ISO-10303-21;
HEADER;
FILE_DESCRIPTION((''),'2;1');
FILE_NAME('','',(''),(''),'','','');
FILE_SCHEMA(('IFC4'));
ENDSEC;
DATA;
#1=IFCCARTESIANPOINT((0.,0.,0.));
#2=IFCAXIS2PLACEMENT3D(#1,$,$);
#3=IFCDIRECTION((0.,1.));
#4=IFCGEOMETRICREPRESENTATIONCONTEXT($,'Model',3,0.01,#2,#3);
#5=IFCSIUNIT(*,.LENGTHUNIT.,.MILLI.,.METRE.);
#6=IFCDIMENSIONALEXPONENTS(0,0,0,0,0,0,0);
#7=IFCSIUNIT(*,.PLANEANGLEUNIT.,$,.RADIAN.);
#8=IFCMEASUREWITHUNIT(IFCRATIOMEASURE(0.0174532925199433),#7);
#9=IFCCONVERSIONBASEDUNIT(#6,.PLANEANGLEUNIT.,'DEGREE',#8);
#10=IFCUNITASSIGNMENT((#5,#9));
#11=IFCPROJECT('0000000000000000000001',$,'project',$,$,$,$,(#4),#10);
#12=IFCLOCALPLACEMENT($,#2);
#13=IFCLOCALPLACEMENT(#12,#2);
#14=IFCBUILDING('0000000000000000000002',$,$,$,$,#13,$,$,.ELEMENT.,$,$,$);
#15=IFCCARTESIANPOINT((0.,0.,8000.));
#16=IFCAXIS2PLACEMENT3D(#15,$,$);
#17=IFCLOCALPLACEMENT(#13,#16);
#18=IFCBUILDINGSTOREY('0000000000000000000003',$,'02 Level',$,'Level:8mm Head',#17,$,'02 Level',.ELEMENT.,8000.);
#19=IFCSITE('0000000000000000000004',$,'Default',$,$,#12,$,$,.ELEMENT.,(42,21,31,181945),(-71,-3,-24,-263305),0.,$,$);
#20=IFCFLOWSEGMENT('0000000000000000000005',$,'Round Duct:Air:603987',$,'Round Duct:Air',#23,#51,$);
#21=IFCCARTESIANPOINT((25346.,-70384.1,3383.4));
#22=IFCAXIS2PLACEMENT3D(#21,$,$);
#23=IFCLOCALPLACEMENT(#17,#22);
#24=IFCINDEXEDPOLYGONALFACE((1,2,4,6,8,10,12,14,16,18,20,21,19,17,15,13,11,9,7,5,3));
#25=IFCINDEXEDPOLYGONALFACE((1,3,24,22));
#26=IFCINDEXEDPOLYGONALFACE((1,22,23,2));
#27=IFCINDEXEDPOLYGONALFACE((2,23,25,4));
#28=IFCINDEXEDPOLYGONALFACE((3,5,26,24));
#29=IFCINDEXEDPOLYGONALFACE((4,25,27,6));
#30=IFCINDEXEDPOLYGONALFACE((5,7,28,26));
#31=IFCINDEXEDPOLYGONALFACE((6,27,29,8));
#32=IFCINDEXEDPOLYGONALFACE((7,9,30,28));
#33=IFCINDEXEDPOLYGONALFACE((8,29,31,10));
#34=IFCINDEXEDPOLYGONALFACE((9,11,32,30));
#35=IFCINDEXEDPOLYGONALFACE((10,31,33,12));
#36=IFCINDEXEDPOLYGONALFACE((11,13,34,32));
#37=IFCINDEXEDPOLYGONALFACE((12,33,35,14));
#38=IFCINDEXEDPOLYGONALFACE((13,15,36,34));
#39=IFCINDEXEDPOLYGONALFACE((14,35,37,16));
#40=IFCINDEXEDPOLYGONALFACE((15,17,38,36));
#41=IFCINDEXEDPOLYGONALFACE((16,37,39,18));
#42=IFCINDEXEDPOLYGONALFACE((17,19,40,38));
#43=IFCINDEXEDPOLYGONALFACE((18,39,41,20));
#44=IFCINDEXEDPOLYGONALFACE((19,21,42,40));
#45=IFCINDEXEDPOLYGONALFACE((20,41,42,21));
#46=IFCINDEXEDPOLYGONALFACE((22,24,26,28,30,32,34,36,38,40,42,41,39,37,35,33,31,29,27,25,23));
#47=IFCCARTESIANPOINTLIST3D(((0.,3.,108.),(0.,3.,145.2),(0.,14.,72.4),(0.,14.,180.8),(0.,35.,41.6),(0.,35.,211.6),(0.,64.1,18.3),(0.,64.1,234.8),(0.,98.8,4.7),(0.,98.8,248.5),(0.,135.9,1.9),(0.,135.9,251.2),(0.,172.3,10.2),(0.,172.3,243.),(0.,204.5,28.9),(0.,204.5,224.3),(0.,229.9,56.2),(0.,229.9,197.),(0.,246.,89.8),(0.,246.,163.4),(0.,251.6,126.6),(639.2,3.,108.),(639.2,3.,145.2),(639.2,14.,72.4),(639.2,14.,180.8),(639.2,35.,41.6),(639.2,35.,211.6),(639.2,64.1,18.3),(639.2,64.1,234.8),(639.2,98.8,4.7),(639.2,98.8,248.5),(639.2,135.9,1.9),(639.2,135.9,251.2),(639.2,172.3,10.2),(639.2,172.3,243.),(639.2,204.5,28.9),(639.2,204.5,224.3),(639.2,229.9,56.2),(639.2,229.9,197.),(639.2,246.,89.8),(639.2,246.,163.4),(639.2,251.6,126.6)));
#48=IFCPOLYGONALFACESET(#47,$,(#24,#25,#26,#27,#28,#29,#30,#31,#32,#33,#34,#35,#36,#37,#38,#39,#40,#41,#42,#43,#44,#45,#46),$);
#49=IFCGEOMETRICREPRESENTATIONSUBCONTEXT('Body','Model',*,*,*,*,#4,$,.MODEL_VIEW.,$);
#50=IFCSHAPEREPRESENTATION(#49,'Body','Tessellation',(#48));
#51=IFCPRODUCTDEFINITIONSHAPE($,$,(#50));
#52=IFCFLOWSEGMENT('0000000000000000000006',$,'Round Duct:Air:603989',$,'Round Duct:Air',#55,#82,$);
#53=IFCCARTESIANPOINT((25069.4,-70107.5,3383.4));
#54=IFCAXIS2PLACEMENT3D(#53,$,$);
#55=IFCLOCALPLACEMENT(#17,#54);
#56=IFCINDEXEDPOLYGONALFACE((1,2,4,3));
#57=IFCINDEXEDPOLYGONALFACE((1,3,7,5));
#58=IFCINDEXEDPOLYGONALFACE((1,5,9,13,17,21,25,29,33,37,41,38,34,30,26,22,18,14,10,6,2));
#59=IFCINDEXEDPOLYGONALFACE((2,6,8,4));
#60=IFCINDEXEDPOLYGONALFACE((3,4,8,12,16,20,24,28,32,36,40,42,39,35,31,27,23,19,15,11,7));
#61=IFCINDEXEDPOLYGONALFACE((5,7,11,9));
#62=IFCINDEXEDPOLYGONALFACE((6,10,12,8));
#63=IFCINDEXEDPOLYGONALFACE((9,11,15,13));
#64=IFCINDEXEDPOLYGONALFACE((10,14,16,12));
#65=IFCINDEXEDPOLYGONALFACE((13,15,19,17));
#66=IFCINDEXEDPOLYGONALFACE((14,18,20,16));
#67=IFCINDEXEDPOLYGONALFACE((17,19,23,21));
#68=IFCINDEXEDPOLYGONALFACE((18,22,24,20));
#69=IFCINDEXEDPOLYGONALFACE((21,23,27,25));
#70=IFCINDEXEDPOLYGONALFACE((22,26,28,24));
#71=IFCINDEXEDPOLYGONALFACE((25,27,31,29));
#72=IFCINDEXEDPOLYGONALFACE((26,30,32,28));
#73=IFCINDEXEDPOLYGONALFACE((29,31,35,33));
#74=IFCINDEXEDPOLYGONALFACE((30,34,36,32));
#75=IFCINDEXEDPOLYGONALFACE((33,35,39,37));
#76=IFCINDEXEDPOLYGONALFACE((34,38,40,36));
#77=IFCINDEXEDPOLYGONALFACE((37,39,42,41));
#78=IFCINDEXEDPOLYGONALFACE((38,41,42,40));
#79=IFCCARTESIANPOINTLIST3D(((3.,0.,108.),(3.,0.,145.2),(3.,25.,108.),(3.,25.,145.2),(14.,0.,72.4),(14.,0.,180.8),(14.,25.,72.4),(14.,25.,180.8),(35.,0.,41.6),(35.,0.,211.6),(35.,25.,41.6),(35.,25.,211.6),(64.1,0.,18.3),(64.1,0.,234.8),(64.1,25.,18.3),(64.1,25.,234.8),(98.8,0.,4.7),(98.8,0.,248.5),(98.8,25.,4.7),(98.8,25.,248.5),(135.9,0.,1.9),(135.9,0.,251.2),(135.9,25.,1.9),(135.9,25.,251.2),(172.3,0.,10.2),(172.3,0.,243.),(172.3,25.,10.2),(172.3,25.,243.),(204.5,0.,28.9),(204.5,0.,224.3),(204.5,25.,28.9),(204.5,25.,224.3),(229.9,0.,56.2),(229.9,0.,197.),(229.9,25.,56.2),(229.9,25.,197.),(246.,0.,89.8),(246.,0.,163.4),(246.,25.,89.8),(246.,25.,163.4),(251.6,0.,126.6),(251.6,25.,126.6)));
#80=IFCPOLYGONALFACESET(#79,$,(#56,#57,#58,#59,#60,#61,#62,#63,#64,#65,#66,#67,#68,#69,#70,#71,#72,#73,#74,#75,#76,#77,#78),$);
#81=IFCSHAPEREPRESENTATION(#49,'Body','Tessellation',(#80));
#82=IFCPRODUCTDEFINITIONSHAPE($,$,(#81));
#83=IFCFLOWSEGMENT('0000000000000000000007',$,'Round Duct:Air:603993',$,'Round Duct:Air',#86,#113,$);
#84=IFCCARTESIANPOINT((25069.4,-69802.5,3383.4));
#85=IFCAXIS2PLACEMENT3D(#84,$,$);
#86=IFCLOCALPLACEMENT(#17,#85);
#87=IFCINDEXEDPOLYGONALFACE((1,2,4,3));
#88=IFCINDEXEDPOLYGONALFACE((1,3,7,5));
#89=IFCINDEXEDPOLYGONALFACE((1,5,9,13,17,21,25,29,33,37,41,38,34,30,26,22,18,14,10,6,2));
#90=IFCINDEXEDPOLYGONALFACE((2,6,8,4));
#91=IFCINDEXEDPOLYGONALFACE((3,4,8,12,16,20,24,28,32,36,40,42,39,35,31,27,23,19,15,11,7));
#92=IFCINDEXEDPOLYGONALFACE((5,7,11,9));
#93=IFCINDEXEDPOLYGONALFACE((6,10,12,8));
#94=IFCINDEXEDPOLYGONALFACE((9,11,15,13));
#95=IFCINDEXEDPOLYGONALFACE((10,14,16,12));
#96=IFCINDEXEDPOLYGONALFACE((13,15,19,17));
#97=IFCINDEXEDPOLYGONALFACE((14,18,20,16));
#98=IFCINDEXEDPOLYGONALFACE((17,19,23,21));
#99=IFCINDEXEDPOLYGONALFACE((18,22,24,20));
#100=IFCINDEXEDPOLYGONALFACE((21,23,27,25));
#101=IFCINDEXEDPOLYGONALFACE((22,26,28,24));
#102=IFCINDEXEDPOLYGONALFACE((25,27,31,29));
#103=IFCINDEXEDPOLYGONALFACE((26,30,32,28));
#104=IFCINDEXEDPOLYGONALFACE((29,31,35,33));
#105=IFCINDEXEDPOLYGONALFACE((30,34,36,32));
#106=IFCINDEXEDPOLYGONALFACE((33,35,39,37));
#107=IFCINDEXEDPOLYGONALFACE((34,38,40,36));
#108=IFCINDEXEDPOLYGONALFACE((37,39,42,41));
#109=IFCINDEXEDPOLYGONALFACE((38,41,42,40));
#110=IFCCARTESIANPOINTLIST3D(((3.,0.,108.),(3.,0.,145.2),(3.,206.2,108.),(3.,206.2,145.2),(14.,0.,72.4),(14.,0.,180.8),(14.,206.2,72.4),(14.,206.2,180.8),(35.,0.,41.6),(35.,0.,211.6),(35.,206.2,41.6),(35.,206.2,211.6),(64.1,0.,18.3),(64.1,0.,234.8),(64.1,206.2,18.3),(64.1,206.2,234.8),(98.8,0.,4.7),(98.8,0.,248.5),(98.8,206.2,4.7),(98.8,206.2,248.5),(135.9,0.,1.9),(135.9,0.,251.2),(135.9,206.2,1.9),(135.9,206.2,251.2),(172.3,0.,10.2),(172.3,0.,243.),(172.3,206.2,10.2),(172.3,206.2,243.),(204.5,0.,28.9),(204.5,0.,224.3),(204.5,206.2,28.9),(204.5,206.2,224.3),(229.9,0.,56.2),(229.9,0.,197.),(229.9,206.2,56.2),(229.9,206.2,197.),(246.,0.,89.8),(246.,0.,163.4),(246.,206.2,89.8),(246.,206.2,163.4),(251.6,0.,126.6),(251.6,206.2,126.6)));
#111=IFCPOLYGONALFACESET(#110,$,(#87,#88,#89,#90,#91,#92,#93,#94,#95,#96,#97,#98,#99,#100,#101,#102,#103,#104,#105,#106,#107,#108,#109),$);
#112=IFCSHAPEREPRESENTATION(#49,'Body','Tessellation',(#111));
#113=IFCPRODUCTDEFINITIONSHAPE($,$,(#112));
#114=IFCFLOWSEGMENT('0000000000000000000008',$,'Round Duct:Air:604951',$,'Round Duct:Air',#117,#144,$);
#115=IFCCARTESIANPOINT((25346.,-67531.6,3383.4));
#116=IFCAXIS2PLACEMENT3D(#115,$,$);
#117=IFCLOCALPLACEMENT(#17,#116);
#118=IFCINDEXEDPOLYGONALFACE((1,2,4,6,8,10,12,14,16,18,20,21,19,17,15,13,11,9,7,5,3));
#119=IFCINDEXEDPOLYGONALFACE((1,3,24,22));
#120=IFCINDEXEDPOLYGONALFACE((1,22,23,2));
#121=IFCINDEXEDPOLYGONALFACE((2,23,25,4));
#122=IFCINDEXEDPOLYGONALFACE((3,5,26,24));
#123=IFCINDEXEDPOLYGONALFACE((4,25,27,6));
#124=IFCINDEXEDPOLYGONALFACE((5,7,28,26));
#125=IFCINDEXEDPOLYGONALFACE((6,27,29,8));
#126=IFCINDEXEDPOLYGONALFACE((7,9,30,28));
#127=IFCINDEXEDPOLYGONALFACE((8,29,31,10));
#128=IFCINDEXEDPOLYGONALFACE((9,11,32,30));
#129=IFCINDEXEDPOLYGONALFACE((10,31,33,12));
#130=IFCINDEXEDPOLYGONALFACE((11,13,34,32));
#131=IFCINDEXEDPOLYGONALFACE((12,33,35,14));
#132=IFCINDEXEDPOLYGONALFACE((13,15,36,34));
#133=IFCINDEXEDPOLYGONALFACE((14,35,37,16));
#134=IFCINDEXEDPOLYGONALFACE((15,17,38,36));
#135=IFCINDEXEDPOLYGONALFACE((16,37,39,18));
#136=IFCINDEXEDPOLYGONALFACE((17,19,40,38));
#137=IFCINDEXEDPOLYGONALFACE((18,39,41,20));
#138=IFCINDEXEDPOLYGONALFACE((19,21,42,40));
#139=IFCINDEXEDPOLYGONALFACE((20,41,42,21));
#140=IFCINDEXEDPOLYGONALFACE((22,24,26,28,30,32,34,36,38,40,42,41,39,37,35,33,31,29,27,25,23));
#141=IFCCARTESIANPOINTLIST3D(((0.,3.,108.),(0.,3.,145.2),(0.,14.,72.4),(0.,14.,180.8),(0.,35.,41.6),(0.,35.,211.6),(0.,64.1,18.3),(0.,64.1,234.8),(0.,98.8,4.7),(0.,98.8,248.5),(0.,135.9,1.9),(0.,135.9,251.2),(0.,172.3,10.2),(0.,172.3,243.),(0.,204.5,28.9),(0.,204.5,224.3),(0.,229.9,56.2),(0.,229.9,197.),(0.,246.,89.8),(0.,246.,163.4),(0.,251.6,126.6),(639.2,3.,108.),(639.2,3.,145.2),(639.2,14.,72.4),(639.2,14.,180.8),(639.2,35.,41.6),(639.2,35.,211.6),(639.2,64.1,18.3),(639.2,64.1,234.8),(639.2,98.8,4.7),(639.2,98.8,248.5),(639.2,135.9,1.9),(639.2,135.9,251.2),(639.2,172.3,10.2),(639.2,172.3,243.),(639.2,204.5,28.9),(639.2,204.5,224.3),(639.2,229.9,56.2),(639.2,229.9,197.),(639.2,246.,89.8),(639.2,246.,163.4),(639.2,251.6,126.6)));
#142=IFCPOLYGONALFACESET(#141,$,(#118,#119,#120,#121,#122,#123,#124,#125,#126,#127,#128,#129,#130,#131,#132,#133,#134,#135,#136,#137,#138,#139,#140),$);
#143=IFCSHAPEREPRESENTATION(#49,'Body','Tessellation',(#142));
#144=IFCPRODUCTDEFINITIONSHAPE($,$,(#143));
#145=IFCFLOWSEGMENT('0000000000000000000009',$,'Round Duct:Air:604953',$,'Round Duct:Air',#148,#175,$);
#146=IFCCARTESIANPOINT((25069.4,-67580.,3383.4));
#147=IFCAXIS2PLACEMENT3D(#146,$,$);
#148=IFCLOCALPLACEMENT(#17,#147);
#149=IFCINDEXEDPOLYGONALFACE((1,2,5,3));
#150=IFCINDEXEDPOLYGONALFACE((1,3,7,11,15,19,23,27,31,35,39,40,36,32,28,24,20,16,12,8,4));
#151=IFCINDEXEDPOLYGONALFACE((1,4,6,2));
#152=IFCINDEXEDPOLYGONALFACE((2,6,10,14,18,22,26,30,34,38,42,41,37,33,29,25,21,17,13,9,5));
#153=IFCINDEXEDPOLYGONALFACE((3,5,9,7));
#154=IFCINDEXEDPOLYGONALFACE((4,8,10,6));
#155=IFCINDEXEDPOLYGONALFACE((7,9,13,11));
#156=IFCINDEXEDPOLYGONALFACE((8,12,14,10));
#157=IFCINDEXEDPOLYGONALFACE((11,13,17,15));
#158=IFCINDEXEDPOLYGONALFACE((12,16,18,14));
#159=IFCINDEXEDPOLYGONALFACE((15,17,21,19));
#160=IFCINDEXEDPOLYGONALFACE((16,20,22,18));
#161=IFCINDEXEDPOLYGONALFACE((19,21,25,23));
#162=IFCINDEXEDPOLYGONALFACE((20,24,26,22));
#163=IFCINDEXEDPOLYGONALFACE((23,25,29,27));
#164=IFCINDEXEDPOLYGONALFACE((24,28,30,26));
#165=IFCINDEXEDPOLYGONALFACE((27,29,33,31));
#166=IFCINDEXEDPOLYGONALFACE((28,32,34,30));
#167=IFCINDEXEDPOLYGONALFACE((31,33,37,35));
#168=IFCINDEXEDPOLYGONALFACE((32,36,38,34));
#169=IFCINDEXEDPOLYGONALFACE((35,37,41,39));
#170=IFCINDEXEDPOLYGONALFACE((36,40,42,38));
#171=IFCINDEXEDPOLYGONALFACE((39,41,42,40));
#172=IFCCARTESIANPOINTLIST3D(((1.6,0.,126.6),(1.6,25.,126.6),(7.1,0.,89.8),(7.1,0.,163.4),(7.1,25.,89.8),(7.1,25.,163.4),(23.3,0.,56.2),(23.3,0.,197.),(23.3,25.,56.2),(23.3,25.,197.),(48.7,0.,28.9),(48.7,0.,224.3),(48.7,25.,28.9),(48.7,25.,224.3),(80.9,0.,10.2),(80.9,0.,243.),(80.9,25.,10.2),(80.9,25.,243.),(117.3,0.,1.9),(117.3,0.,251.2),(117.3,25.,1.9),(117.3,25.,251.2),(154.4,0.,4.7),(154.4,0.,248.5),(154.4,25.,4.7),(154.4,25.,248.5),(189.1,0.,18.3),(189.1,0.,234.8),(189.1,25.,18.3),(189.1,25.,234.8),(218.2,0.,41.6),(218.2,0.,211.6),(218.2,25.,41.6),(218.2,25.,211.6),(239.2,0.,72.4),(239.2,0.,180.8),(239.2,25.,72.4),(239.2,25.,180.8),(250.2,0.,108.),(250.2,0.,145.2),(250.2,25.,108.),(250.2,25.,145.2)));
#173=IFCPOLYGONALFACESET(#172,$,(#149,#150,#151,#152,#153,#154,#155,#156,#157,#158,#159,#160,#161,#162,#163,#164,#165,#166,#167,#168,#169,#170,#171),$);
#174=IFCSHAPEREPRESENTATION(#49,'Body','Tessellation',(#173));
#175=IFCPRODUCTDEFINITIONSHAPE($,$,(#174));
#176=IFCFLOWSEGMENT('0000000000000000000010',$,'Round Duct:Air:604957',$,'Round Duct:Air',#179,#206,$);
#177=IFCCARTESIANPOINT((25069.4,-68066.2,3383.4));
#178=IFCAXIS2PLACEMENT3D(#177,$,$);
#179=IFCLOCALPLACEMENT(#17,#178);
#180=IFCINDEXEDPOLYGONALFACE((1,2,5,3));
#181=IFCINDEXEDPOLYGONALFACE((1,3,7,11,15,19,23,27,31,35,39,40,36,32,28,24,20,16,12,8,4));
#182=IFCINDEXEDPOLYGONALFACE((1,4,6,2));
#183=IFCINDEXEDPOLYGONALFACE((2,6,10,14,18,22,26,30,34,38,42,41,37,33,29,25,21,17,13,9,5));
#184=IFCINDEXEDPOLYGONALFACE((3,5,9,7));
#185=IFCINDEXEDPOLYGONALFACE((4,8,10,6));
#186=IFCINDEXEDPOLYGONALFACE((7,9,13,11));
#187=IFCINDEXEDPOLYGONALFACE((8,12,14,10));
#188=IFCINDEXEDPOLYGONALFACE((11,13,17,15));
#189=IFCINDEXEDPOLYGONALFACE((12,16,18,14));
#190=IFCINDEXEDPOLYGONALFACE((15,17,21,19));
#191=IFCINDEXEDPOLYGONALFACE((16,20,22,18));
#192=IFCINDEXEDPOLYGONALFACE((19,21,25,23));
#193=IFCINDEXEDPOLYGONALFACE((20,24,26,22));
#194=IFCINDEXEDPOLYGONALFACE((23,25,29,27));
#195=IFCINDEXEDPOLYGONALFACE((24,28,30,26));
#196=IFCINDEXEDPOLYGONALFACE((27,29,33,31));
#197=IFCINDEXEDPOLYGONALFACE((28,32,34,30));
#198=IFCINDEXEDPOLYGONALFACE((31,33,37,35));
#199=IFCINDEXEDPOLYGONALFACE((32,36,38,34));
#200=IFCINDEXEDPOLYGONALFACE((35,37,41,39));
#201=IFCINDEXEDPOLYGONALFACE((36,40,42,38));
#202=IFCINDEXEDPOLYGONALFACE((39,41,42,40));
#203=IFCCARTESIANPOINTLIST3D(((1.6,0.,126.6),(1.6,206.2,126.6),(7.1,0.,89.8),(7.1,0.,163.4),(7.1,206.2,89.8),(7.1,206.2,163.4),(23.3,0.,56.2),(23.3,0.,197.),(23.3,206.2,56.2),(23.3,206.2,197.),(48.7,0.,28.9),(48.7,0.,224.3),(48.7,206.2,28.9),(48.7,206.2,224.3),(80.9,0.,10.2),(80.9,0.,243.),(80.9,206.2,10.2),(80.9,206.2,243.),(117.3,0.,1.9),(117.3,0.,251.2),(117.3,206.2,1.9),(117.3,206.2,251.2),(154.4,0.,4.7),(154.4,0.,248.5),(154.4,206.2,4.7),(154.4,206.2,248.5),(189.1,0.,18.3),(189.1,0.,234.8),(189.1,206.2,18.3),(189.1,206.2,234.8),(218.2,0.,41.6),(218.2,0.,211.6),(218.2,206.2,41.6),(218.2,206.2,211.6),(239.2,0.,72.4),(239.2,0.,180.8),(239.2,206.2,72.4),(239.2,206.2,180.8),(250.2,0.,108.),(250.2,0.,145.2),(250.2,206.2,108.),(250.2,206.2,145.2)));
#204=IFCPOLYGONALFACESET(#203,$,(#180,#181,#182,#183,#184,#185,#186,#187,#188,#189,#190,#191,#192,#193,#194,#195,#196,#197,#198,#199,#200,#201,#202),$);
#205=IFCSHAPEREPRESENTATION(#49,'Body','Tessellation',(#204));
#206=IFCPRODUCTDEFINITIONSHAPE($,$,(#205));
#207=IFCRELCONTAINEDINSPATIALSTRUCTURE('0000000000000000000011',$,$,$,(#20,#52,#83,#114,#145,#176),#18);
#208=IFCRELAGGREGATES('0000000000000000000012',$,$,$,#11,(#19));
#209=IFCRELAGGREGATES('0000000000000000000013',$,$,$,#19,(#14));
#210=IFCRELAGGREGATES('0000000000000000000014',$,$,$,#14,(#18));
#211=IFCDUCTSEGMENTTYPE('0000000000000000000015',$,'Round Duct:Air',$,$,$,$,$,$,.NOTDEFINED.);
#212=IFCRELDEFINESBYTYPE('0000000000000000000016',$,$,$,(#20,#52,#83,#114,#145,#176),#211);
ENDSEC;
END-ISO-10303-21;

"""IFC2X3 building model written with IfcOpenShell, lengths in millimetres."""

from ifc_helpers import new_model, entity, si_unit, converted_unit, direction, frame, origin, origin_2d_with_axis, place, context, subcontext, project, spatial, circle, extrude, type_object, element, save


model = new_model("IFC2X3")

# Units and contexts
model_context = context("Model", 3, precision=0.01, world=origin(), true_north=direction((0.0, 1.0)))
body_context = subcontext(model_context, "Body", "Model", "MODEL_VIEW")
ifc_project = project(units=[si_unit("LENGTHUNIT", "METRE", prefix="MILLI"), converted_unit("PLANEANGLEUNIT", "DEGREE", entity("IfcRatioMeasure", 0.0174532925199433), si_unit("PLANEANGLEUNIT", "RADIAN"), dimensions=[0, 0, 0, 0, 0, 0, 0])], contexts=[model_context])

# Site, building, storey
site_placement = place(None, origin())
site = spatial("IfcSite", under=ifc_project, at=site_placement, Name="Default", CompositionType="ELEMENT", RefLatitude=(42, 21, 31, 181945), RefLongitude=(-71, -3, -24, -263305), RefElevation=0.0)
building_placement = place(site_placement, origin())
building = spatial("IfcBuilding", under=site, at=building_placement, CompositionType="ELEMENT")
storey_placement = place(building_placement, frame((0.0, 0.0, 8000.0)))
storey = spatial("IfcBuildingStorey", under=building, at=storey_placement, Name="02 Level", ObjectType="Level:8mm Head", LongName="02 Level", CompositionType="ELEMENT", Elevation=8000.0)

# Flow segments
duct_segment_type = type_object("IfcDuctSegmentType", Name="Round Duct:Air", PredefinedType="NOTDEFINED")
flow_segment_1_placement = place(storey_placement, frame((25346.0, -70384.1, 3383.4)))
element("IfcFlowSegment", 1, at=flow_segment_1_placement, inside=storey, type_object=duct_segment_type, Name="Round Duct:Air:603987", ObjectType="Round Duct:Air", context=body_context, shape_type="SweptSolid", body=[
    extrude(circle(Radius=125.0, at=origin_2d_with_axis()), frame((0.0, 126.6, 126.6), z_axis=(1.0, 0.0, 0.0), x_axis=(0.0, 1.0, 0.0)), (0.0, 0.0, 1.0), 639.2),
])
flow_segment_2_placement = place(storey_placement, frame((25069.4, -70107.5, 3383.4)))
element("IfcFlowSegment", 2, at=flow_segment_2_placement, inside=storey, type_object=duct_segment_type, Name="Round Duct:Air:603989", ObjectType="Round Duct:Air", context=body_context, shape_type="SweptSolid", body=[
    extrude(circle(Radius=125.0, at=origin_2d_with_axis()), frame((126.6, 0.0, 126.6), z_axis=(0.0, 1.0, 0.0), x_axis=(1.0, 0.0, 0.0)), (0.0, 0.0, 1.0), 25.0),
])
flow_segment_3_placement = place(storey_placement, frame((25069.4, -69802.5, 3383.4)))
element("IfcFlowSegment", 3, at=flow_segment_3_placement, inside=storey, type_object=duct_segment_type, Name="Round Duct:Air:603993", ObjectType="Round Duct:Air", context=body_context, shape_type="SweptSolid", body=[
    extrude(circle(Radius=125.0, at=origin_2d_with_axis()), frame((126.6, 0.0, 126.6), z_axis=(0.0, 1.0, 0.0), x_axis=(1.0, 0.0, 0.0)), (0.0, 0.0, 1.0), 206.2),
])
flow_segment_4_placement = place(storey_placement, frame((25346.0, -67531.6, 3383.4)))
element("IfcFlowSegment", 4, at=flow_segment_4_placement, inside=storey, type_object=duct_segment_type, Name="Round Duct:Air:604951", ObjectType="Round Duct:Air", context=body_context, shape_type="SweptSolid", body=[
    extrude(circle(Radius=125.0, at=origin_2d_with_axis()), frame((0.0, 126.6, 126.6), z_axis=(1.0, 0.0, 0.0), x_axis=(0.0, 1.0, 0.0)), (0.0, 0.0, 1.0), 639.2),
])
flow_segment_5_placement = place(storey_placement, frame((25069.4, -67580.0, 3383.4)))
element("IfcFlowSegment", 5, at=flow_segment_5_placement, inside=storey, type_object=duct_segment_type, Name="Round Duct:Air:604953", ObjectType="Round Duct:Air", context=body_context, shape_type="SweptSolid", body=[
    extrude(circle(Radius=125.0, at=origin_2d_with_axis()), frame((126.6, 0.0, 126.6), z_axis=(0.0, 1.0, 0.0), x_axis=(-1.0, 0.0, 0.0)), (0.0, 0.0, 1.0), 25.0),
])
flow_segment_6_placement = place(storey_placement, frame((25069.4, -68066.2, 3383.4)))
element("IfcFlowSegment", 6, at=flow_segment_6_placement, inside=storey, type_object=duct_segment_type, Name="Round Duct:Air:604957", ObjectType="Round Duct:Air", context=body_context, shape_type="SweptSolid", body=[
    extrude(circle(Radius=125.0, at=origin_2d_with_axis()), frame((126.6, 0.0, 126.6), z_axis=(0.0, 1.0, 0.0), x_axis=(-1.0, 0.0, 0.0)), (0.0, 0.0, 1.0), 206.2),
])

save(model, "model.ifc")
